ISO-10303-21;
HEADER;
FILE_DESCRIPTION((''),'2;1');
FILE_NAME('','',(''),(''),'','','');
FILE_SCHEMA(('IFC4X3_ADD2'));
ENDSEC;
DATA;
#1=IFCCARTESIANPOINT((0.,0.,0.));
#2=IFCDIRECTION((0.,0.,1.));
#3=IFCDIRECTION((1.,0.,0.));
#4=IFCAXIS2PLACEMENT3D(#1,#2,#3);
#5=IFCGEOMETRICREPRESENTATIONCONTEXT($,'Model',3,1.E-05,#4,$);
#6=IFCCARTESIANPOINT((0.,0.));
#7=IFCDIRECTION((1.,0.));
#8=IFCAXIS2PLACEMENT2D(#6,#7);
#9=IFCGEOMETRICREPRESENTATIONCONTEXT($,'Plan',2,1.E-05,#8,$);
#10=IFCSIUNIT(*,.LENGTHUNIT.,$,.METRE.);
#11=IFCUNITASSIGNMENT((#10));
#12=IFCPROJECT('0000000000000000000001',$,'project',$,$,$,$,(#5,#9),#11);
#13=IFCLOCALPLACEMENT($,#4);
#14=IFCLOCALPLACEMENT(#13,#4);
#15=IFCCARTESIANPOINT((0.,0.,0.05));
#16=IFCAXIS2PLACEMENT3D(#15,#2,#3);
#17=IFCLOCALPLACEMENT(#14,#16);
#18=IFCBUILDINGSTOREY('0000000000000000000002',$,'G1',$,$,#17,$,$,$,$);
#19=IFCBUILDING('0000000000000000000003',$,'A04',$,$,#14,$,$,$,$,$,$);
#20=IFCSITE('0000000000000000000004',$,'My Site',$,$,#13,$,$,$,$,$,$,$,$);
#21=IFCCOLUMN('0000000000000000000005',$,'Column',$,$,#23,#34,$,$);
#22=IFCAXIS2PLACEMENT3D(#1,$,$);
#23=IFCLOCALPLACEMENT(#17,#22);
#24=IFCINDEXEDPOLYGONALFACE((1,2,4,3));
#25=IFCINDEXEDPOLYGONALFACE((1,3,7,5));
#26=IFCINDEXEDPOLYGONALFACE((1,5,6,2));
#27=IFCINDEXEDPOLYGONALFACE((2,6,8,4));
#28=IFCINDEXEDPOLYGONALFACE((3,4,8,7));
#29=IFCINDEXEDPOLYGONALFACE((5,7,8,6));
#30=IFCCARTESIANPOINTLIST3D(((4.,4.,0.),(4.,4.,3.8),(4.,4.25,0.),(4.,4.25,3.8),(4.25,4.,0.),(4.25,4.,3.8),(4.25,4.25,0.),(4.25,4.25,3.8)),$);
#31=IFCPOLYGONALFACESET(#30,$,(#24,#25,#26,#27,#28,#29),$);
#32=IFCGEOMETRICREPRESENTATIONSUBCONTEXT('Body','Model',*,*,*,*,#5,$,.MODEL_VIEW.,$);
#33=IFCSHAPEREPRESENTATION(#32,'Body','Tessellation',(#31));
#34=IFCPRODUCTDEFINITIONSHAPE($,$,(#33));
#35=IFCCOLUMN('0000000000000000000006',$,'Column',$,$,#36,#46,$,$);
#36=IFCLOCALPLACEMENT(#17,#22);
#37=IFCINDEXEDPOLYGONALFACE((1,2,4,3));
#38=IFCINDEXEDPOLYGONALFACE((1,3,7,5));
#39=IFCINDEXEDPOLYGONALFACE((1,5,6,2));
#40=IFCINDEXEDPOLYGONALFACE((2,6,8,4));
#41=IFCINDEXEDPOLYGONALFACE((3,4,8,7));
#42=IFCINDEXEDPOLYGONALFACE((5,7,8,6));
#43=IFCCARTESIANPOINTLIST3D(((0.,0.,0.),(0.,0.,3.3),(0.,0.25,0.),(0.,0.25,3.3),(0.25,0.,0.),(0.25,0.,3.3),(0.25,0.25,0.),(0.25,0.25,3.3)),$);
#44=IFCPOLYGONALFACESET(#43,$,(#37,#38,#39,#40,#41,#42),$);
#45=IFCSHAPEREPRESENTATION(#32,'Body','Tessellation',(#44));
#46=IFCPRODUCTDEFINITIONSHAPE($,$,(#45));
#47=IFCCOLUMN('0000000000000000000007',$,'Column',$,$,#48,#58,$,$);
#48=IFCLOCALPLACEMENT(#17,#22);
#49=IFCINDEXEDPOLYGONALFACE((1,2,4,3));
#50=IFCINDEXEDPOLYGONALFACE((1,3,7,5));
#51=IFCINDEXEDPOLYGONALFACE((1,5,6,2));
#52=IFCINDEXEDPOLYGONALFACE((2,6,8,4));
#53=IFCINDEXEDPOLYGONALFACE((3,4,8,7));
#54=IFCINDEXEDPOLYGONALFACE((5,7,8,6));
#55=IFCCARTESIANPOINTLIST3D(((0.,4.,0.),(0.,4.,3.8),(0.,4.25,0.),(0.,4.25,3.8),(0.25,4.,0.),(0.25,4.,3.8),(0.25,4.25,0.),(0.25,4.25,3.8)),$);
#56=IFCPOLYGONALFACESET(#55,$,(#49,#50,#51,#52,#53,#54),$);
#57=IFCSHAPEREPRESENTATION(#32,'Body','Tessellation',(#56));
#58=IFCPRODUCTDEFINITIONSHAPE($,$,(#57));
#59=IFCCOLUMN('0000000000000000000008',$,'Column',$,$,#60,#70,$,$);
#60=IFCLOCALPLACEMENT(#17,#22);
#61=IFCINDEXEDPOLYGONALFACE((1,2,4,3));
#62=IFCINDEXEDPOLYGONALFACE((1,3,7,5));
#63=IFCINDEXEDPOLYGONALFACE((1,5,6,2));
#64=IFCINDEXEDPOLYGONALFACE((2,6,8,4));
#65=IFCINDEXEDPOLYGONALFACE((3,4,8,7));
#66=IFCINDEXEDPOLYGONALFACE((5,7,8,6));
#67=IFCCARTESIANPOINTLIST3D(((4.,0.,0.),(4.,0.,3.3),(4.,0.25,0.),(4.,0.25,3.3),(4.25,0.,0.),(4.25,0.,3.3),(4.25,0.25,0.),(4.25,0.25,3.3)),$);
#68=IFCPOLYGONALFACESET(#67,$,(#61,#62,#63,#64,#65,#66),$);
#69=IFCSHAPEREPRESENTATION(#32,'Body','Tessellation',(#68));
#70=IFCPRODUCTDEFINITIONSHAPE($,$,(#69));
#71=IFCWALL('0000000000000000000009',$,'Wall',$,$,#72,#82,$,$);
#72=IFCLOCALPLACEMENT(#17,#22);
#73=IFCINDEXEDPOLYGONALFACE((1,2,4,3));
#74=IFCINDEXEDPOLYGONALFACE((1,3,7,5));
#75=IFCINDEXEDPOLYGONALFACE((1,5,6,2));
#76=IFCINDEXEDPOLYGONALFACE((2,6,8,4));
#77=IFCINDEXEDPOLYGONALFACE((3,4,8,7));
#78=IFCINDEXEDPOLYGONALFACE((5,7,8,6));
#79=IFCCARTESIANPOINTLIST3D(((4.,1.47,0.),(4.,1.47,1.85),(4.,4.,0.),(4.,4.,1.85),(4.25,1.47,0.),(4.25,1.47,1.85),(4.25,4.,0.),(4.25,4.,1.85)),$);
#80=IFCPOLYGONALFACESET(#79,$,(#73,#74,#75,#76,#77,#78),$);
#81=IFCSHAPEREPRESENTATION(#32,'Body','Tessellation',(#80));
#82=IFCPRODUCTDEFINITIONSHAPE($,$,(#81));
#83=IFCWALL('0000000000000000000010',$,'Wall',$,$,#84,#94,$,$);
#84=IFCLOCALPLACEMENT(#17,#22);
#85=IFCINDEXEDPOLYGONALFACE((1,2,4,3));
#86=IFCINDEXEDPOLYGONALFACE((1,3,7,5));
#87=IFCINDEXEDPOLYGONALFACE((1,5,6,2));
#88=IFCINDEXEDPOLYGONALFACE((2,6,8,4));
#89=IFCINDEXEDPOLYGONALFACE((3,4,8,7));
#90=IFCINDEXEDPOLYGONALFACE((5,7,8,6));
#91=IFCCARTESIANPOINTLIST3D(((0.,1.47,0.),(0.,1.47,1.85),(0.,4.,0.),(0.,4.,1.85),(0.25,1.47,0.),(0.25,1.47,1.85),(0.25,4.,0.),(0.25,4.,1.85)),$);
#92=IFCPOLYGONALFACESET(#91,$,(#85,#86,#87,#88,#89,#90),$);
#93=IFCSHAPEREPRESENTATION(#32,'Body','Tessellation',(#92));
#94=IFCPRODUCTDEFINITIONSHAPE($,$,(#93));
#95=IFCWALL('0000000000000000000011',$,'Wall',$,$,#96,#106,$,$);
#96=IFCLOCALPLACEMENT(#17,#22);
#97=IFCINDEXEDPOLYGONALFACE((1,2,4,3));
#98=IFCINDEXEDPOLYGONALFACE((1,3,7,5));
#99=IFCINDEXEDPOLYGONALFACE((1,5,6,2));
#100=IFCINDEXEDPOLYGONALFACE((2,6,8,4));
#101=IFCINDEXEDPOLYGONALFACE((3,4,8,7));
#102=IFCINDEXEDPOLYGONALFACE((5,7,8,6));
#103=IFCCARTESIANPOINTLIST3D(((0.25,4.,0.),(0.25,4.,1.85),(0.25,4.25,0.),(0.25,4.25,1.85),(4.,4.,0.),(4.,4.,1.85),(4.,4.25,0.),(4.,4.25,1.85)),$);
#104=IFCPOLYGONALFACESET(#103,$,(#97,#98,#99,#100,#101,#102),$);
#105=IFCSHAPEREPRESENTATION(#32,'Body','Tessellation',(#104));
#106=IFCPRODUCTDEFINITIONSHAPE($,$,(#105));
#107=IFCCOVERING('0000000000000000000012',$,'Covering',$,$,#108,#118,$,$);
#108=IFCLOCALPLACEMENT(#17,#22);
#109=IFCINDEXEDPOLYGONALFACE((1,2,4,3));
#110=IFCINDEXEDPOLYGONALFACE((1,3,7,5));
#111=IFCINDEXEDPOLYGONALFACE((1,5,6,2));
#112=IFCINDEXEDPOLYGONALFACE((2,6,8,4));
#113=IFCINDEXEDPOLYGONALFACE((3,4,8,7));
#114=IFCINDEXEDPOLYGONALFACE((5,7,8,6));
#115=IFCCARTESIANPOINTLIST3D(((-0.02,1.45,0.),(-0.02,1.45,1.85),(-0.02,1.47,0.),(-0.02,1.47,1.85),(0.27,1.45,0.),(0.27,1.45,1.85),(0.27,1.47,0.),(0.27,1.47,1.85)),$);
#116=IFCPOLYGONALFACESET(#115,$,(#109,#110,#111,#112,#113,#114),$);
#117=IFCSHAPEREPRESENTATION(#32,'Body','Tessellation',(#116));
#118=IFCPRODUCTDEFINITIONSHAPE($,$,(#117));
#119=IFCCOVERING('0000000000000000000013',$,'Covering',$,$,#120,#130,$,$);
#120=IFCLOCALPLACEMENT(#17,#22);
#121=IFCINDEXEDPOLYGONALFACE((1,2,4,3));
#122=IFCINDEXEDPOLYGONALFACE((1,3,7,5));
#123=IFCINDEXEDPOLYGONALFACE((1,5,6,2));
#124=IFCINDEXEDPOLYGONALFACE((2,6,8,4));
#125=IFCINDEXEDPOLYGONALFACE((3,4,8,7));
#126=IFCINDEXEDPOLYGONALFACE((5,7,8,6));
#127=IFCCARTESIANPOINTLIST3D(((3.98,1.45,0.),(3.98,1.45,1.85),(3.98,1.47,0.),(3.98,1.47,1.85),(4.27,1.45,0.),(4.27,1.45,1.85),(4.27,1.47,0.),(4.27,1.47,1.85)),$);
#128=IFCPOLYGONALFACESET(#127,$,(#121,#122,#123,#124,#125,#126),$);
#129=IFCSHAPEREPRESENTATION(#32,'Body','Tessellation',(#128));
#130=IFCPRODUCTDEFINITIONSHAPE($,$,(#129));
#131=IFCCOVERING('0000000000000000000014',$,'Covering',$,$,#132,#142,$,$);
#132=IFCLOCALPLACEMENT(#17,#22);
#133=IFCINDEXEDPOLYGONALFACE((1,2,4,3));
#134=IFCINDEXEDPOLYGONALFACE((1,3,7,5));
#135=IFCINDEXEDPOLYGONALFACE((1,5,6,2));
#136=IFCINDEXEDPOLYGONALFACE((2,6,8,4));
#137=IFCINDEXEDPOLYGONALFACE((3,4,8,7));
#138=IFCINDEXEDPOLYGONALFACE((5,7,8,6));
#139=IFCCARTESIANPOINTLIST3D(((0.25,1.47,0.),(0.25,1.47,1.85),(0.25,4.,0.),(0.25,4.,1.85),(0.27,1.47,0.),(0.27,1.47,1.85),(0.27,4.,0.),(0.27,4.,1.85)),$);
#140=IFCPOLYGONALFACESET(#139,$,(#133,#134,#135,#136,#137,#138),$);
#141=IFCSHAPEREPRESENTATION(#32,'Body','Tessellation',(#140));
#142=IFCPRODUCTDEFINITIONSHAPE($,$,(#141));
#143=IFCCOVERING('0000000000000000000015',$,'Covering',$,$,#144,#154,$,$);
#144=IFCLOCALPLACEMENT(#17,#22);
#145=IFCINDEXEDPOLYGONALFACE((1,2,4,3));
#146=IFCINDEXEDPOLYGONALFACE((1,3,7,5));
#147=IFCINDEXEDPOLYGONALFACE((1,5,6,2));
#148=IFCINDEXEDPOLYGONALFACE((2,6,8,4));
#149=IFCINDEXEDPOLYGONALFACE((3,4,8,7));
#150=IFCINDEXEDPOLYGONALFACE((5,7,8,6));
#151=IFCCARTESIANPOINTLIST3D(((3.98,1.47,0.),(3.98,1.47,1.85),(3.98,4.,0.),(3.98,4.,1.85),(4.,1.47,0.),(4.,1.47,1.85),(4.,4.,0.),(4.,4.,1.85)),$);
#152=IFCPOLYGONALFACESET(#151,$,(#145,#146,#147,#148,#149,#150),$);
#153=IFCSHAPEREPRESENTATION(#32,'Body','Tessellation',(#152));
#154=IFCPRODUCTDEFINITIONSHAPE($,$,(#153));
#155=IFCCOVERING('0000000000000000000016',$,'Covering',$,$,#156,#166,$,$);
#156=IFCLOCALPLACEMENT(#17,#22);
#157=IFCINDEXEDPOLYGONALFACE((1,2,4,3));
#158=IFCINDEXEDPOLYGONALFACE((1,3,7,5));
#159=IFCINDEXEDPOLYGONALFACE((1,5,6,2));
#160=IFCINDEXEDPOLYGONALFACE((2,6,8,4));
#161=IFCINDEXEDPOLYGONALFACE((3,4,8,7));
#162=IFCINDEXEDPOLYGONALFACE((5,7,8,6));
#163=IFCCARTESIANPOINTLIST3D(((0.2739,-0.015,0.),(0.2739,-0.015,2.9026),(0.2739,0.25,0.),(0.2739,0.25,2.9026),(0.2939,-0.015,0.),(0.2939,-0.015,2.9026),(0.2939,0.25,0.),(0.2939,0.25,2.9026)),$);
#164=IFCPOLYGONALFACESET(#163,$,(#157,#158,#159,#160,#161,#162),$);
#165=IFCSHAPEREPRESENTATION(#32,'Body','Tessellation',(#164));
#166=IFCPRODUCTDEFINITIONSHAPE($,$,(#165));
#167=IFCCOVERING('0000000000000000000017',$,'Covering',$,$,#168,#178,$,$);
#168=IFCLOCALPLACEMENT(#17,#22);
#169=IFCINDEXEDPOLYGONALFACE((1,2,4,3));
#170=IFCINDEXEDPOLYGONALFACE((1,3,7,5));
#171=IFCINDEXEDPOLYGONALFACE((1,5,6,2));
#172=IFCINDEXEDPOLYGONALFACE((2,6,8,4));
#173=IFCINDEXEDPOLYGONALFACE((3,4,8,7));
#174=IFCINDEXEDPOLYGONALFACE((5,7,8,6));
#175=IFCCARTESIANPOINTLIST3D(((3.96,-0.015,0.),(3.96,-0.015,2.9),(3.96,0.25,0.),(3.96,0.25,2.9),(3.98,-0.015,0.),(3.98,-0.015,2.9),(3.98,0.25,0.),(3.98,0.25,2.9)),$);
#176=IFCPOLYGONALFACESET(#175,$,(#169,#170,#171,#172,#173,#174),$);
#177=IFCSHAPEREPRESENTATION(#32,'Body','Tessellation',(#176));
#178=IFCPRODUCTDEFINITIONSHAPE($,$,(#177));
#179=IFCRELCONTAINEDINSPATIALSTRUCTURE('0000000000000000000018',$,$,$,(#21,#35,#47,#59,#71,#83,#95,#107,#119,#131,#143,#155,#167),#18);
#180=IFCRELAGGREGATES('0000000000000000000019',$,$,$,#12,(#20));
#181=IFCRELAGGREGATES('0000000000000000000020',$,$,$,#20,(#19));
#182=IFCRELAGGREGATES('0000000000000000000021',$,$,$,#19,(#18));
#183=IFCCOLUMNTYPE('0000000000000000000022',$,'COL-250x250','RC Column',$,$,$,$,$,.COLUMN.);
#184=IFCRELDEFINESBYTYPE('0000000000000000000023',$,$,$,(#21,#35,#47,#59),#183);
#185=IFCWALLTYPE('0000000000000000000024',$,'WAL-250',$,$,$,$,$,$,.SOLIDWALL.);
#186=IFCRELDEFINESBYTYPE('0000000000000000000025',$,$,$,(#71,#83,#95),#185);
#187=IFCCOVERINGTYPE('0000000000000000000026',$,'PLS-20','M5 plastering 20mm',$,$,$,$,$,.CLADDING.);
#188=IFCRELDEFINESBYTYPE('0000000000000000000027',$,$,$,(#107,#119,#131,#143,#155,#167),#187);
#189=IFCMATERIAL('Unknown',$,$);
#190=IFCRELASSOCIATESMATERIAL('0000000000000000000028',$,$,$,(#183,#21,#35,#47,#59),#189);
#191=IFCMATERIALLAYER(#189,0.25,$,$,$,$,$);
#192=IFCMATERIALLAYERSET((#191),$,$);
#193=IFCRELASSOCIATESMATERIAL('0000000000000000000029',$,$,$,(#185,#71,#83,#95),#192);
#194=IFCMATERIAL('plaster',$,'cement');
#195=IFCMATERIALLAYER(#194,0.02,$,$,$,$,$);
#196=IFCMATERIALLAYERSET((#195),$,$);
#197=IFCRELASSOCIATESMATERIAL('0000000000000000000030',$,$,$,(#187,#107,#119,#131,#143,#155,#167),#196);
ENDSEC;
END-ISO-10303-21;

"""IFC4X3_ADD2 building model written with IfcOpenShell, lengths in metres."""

from ifc_helpers import new_model, si_unit, frame, origin_with_axes, origin_2d_with_axis, place, context, subcontext, project, spatial, line, indexed_curve, rectangle, outline, extrude, material, layer, layer_set, layer_usage, material_profile, profile_set, profile_usage, type_object, element, save


model = new_model("IFC4X3_ADD2")

# Units and contexts
model_context = context("Model", 3, precision=1e-05, world=origin_with_axes())
plan_context = context("Plan", 2, precision=1e-05, world=origin_2d_with_axis())
body_context = subcontext(model_context, "Body", "Model", "MODEL_VIEW")
ifc_project = project(units=[si_unit("LENGTHUNIT", "METRE")], contexts=[model_context, plan_context])

# Site, building, storey
site_placement = place(None, origin_with_axes())
site = spatial("IfcSite", under=ifc_project, at=site_placement, Name="My Site")
building_placement = place(site_placement, origin_with_axes())
building = spatial("IfcBuilding", under=site, at=building_placement, Name="A04")
storey_placement = place(building_placement, frame((0.0, 0.0, 0.05), z_axis=(0.0, 0.0, 1.0), x_axis=(1.0, 0.0, 0.0)))
storey = spatial("IfcBuildingStorey", under=building, at=storey_placement, Name="G1")

# Columns
ifc_material_1 = material(Name="Unknown")
ifc_material_profile = material_profile(ifc_material_1, rectangle(XDim=0.25, YDim=0.25))
ifc_profile_set = profile_set([ifc_material_profile])
ifc_profile_usage_1 = profile_usage(ifc_profile_set, cardinal=5)
column_type = type_object("IfcColumnType", Name="COL-250x250", Description="RC Column", PredefinedType="COLUMN", material=ifc_profile_set)
column_1_placement = place(storey_placement, frame((4.125, 4.125, 0.0), z_axis=(0.0, 0.0, 1.0), x_axis=(1.0, 0.0, 0.0)))
element("IfcColumn", 1, at=column_1_placement, inside=storey, type_object=column_type, material=ifc_profile_usage_1, Name="Column", context=body_context, shape_type="SweptSolid", body=[
    extrude(rectangle(XDim=0.25, YDim=0.25), origin_with_axes(), (0.0, 0.0, 1.0), 3.8),
])
ifc_profile_usage_2 = profile_usage(ifc_profile_set, cardinal=5)
column_2_placement = place(storey_placement, frame((0.125, 0.125, 0.0), z_axis=(0.0, 0.0, 1.0), x_axis=(1.0, 0.0, 0.0)))
element("IfcColumn", 2, at=column_2_placement, inside=storey, type_object=column_type, material=ifc_profile_usage_2, Name="Column", context=body_context, shape_type="SweptSolid", body=[
    extrude(rectangle(XDim=0.25, YDim=0.25), origin_with_axes(), (0.0, 0.0, 1.0), 3.3),
])
ifc_profile_usage_3 = profile_usage(ifc_profile_set, cardinal=5)
column_3_placement = place(storey_placement, frame((0.125, 4.125, 0.0), z_axis=(0.0, 0.0, 1.0), x_axis=(1.0, 0.0, 0.0)))
element("IfcColumn", 3, at=column_3_placement, inside=storey, type_object=column_type, material=ifc_profile_usage_3, Name="Column", context=body_context, shape_type="SweptSolid", body=[
    extrude(rectangle(XDim=0.25, YDim=0.25), origin_with_axes(), (0.0, 0.0, 1.0), 3.8),
])
ifc_profile_usage_4 = profile_usage(ifc_profile_set, cardinal=5)
column_4_placement = place(storey_placement, frame((4.125, 0.125, 0.0), z_axis=(0.0, 0.0, 1.0), x_axis=(1.0, 0.0, 0.0)))
element("IfcColumn", 4, at=column_4_placement, inside=storey, type_object=column_type, material=ifc_profile_usage_4, Name="Column", context=body_context, shape_type="SweptSolid", body=[
    extrude(rectangle(XDim=0.25, YDim=0.25), origin_with_axes(), (0.0, 0.0, 1.0), 3.3),
])

# Walls
ifc_layer_1 = layer(ifc_material_1, 0.25)
ifc_layer_set_1 = layer_set([ifc_layer_1])
ifc_layer_usage_1 = layer_usage(ifc_layer_set_1, "AXIS2", "POSITIVE", 0.0)
wall_type = type_object("IfcWallType", Name="WAL-250", PredefinedType="SOLIDWALL", material=ifc_layer_set_1)
wall_1_placement = place(storey_placement, frame((4.25, 1.47, 0.0), z_axis=(0.0, 0.0, 1.0), x_axis=(0.0, 1.0, 0.0)))
element("IfcWall", 5, at=wall_1_placement, inside=storey, type_object=wall_type, material=ifc_layer_usage_1, Name="Wall", context=body_context, shape_type="SweptSolid", body=[
    extrude(outline(indexed_curve([(0.0, 0.0), (0.0, 0.25), (2.53, 0.25), (2.53, 0.0)], segments=[line(1, 2, 3, 4, 1)])), origin_with_axes(), (0.0, 0.0, 1.0), 1.85),
])
ifc_layer_usage_2 = layer_usage(ifc_layer_set_1, "AXIS2", "NEGATIVE", 0.25)
wall_2_placement = place(storey_placement, frame((0.0, 4.0, 0.0), z_axis=(0.0, 0.0, 1.0), x_axis=(0.0, -1.0, 0.0)))
element("IfcWall", 6, at=wall_2_placement, inside=storey, type_object=wall_type, material=ifc_layer_usage_2, Name="Wall", context=body_context, shape_type="SweptSolid", body=[
    extrude(outline(indexed_curve([(0.0, 0.0), (0.0, 0.25), (2.53, 0.25), (2.53, 0.0)], segments=[line(1, 2, 3, 4, 1)])), origin_with_axes(), (0.0, 0.0, 1.0), 1.85),
])
ifc_layer_usage_3 = layer_usage(ifc_layer_set_1, "AXIS2", "POSITIVE", 0.0)
wall_3_placement = place(storey_placement, frame((4.0, 4.25, 0.0), z_axis=(0.0, 0.0, 1.0), x_axis=(-1.0, 0.0, 0.0)))
element("IfcWall", 7, at=wall_3_placement, inside=storey, type_object=wall_type, material=ifc_layer_usage_3, Name="Wall", context=body_context, shape_type="SweptSolid", body=[
    extrude(outline(indexed_curve([(0.0, 0.0), (0.0, 0.25), (3.75, 0.25), (3.75, 0.0)], segments=[line(1, 2, 3, 4, 1)])), origin_with_axes(), (0.0, 0.0, 1.0), 1.85),
])

# Shared definitions
ifc_material_2 = material(Name="plaster", Category="cement")
ifc_layer_2 = layer(ifc_material_2, 0.02)
ifc_layer_set_2 = layer_set([ifc_layer_2])
covering_type = type_object("IfcCoveringType", Name="PLS-20", Description="M5 plastering 20mm", PredefinedType="CLADDING", material=ifc_layer_set_2)

# Coverings
ifc_layer_usage_4 = layer_usage(ifc_layer_set_2, "AXIS2", "POSITIVE", 0.0)
covering_1_placement = place(storey_placement, frame((-0.02, 1.45, 0.0), z_axis=(0.0, 0.0, 1.0), x_axis=(1.0, 0.0, 0.0)))
element("IfcCovering", 8, at=covering_1_placement, inside=storey, type_object=covering_type, material=ifc_layer_usage_4, Name="Covering", context=body_context, shape_type="SweptSolid", body=[
    extrude(outline(indexed_curve([(0.0, 0.0), (0.0, 0.02), (0.29, 0.02), (0.29, 0.0)], segments=[line(1, 2, 3, 4, 1)])), origin_with_axes(), (0.0, 0.0, 1.0), 1.85),
])
ifc_layer_usage_5 = layer_usage(ifc_layer_set_2, "AXIS2", "POSITIVE", 0.0)
covering_2_placement = place(storey_placement, frame((3.98, 1.45, 0.0), z_axis=(0.0, 0.0, 1.0), x_axis=(1.0, 0.0, 0.0)))
element("IfcCovering", 9, at=covering_2_placement, inside=storey, type_object=covering_type, material=ifc_layer_usage_5, Name="Covering", context=body_context, shape_type="SweptSolid", body=[
    extrude(outline(indexed_curve([(0.0, 0.0), (0.0, 0.02), (0.29, 0.02), (0.29, 0.0)], segments=[line(1, 2, 3, 4, 1)])), origin_with_axes(), (0.0, 0.0, 1.0), 1.85),
])
ifc_layer_usage_6 = layer_usage(ifc_layer_set_2, "AXIS2", "POSITIVE", 0.0)
covering_3_placement = place(storey_placement, frame((0.27, 1.47, 0.0), z_axis=(0.0, 0.0, 1.0), x_axis=(0.0, 1.0, 0.0)))
element("IfcCovering", 10, at=covering_3_placement, inside=storey, type_object=covering_type, material=ifc_layer_usage_6, Name="Covering", context=body_context, shape_type="SweptSolid", body=[
    extrude(outline(indexed_curve([(0.0, 0.0), (0.0, 0.02), (2.53, 0.02), (2.53, 0.0)], segments=[line(1, 2, 3, 4, 1)])), origin_with_axes(), (0.0, 0.0, 1.0), 1.85),
])

# Covering
ifc_layer_usage_7 = layer_usage(ifc_layer_set_2, "AXIS2", "POSITIVE", 0.0)
covering_4_placement = place(storey_placement, frame((4.0, 1.47, 0.0), z_axis=(0.0, 0.0, 1.0), x_axis=(0.0, 1.0, 0.0)))
element("IfcCovering", 11, at=covering_4_placement, inside=storey, type_object=covering_type, material=ifc_layer_usage_7, Name="Covering", context=body_context, shape_type="SweptSolid", body=[
    extrude(outline(indexed_curve([(0.0, 0.0), (0.0, 0.02), (2.53, 0.02), (2.53, 0.0)], segments=[line(1, 2, 3, 4, 1)])), origin_with_axes(), (0.0, 0.0, 1.0), 1.85),
])

# Coverings
ifc_layer_usage_8 = layer_usage(ifc_layer_set_2, "AXIS2", "POSITIVE", 0.0)
covering_5_placement = place(storey_placement, frame((0.2939, -0.015, 0.0), z_axis=(0.0, 0.0, 1.0), x_axis=(0.0, 1.0, 0.0)))
element("IfcCovering", 12, at=covering_5_placement, inside=storey, type_object=covering_type, material=ifc_layer_usage_8, Name="Covering", context=body_context, shape_type="SweptSolid", body=[
    extrude(outline(indexed_curve([(0.0, 0.0), (0.0, 0.02), (0.265, 0.02), (0.265, 0.0)], segments=[line(1, 2, 3, 4, 1)])), origin_with_axes(), (0.0, 0.0, 1.0), 2.9026),
])
ifc_layer_usage_9 = layer_usage(ifc_layer_set_2, "AXIS2", "POSITIVE", 0.0)
covering_6_placement = place(storey_placement, frame((3.98, -0.015, 0.0), z_axis=(0.0, 0.0, 1.0), x_axis=(0.0, 1.0, 0.0)))
element("IfcCovering", 13, at=covering_6_placement, inside=storey, type_object=covering_type, material=ifc_layer_usage_9, Name="Covering", context=body_context, shape_type="SweptSolid", body=[
    extrude(outline(indexed_curve([(0.0, 0.0), (0.0, 0.02), (0.265, 0.02), (0.265, 0.0)], segments=[line(1, 2, 3, 4, 1)])), origin_with_axes(), (0.0, 0.0, 1.0), 2.9),
])

save(model, "model.ifc")
